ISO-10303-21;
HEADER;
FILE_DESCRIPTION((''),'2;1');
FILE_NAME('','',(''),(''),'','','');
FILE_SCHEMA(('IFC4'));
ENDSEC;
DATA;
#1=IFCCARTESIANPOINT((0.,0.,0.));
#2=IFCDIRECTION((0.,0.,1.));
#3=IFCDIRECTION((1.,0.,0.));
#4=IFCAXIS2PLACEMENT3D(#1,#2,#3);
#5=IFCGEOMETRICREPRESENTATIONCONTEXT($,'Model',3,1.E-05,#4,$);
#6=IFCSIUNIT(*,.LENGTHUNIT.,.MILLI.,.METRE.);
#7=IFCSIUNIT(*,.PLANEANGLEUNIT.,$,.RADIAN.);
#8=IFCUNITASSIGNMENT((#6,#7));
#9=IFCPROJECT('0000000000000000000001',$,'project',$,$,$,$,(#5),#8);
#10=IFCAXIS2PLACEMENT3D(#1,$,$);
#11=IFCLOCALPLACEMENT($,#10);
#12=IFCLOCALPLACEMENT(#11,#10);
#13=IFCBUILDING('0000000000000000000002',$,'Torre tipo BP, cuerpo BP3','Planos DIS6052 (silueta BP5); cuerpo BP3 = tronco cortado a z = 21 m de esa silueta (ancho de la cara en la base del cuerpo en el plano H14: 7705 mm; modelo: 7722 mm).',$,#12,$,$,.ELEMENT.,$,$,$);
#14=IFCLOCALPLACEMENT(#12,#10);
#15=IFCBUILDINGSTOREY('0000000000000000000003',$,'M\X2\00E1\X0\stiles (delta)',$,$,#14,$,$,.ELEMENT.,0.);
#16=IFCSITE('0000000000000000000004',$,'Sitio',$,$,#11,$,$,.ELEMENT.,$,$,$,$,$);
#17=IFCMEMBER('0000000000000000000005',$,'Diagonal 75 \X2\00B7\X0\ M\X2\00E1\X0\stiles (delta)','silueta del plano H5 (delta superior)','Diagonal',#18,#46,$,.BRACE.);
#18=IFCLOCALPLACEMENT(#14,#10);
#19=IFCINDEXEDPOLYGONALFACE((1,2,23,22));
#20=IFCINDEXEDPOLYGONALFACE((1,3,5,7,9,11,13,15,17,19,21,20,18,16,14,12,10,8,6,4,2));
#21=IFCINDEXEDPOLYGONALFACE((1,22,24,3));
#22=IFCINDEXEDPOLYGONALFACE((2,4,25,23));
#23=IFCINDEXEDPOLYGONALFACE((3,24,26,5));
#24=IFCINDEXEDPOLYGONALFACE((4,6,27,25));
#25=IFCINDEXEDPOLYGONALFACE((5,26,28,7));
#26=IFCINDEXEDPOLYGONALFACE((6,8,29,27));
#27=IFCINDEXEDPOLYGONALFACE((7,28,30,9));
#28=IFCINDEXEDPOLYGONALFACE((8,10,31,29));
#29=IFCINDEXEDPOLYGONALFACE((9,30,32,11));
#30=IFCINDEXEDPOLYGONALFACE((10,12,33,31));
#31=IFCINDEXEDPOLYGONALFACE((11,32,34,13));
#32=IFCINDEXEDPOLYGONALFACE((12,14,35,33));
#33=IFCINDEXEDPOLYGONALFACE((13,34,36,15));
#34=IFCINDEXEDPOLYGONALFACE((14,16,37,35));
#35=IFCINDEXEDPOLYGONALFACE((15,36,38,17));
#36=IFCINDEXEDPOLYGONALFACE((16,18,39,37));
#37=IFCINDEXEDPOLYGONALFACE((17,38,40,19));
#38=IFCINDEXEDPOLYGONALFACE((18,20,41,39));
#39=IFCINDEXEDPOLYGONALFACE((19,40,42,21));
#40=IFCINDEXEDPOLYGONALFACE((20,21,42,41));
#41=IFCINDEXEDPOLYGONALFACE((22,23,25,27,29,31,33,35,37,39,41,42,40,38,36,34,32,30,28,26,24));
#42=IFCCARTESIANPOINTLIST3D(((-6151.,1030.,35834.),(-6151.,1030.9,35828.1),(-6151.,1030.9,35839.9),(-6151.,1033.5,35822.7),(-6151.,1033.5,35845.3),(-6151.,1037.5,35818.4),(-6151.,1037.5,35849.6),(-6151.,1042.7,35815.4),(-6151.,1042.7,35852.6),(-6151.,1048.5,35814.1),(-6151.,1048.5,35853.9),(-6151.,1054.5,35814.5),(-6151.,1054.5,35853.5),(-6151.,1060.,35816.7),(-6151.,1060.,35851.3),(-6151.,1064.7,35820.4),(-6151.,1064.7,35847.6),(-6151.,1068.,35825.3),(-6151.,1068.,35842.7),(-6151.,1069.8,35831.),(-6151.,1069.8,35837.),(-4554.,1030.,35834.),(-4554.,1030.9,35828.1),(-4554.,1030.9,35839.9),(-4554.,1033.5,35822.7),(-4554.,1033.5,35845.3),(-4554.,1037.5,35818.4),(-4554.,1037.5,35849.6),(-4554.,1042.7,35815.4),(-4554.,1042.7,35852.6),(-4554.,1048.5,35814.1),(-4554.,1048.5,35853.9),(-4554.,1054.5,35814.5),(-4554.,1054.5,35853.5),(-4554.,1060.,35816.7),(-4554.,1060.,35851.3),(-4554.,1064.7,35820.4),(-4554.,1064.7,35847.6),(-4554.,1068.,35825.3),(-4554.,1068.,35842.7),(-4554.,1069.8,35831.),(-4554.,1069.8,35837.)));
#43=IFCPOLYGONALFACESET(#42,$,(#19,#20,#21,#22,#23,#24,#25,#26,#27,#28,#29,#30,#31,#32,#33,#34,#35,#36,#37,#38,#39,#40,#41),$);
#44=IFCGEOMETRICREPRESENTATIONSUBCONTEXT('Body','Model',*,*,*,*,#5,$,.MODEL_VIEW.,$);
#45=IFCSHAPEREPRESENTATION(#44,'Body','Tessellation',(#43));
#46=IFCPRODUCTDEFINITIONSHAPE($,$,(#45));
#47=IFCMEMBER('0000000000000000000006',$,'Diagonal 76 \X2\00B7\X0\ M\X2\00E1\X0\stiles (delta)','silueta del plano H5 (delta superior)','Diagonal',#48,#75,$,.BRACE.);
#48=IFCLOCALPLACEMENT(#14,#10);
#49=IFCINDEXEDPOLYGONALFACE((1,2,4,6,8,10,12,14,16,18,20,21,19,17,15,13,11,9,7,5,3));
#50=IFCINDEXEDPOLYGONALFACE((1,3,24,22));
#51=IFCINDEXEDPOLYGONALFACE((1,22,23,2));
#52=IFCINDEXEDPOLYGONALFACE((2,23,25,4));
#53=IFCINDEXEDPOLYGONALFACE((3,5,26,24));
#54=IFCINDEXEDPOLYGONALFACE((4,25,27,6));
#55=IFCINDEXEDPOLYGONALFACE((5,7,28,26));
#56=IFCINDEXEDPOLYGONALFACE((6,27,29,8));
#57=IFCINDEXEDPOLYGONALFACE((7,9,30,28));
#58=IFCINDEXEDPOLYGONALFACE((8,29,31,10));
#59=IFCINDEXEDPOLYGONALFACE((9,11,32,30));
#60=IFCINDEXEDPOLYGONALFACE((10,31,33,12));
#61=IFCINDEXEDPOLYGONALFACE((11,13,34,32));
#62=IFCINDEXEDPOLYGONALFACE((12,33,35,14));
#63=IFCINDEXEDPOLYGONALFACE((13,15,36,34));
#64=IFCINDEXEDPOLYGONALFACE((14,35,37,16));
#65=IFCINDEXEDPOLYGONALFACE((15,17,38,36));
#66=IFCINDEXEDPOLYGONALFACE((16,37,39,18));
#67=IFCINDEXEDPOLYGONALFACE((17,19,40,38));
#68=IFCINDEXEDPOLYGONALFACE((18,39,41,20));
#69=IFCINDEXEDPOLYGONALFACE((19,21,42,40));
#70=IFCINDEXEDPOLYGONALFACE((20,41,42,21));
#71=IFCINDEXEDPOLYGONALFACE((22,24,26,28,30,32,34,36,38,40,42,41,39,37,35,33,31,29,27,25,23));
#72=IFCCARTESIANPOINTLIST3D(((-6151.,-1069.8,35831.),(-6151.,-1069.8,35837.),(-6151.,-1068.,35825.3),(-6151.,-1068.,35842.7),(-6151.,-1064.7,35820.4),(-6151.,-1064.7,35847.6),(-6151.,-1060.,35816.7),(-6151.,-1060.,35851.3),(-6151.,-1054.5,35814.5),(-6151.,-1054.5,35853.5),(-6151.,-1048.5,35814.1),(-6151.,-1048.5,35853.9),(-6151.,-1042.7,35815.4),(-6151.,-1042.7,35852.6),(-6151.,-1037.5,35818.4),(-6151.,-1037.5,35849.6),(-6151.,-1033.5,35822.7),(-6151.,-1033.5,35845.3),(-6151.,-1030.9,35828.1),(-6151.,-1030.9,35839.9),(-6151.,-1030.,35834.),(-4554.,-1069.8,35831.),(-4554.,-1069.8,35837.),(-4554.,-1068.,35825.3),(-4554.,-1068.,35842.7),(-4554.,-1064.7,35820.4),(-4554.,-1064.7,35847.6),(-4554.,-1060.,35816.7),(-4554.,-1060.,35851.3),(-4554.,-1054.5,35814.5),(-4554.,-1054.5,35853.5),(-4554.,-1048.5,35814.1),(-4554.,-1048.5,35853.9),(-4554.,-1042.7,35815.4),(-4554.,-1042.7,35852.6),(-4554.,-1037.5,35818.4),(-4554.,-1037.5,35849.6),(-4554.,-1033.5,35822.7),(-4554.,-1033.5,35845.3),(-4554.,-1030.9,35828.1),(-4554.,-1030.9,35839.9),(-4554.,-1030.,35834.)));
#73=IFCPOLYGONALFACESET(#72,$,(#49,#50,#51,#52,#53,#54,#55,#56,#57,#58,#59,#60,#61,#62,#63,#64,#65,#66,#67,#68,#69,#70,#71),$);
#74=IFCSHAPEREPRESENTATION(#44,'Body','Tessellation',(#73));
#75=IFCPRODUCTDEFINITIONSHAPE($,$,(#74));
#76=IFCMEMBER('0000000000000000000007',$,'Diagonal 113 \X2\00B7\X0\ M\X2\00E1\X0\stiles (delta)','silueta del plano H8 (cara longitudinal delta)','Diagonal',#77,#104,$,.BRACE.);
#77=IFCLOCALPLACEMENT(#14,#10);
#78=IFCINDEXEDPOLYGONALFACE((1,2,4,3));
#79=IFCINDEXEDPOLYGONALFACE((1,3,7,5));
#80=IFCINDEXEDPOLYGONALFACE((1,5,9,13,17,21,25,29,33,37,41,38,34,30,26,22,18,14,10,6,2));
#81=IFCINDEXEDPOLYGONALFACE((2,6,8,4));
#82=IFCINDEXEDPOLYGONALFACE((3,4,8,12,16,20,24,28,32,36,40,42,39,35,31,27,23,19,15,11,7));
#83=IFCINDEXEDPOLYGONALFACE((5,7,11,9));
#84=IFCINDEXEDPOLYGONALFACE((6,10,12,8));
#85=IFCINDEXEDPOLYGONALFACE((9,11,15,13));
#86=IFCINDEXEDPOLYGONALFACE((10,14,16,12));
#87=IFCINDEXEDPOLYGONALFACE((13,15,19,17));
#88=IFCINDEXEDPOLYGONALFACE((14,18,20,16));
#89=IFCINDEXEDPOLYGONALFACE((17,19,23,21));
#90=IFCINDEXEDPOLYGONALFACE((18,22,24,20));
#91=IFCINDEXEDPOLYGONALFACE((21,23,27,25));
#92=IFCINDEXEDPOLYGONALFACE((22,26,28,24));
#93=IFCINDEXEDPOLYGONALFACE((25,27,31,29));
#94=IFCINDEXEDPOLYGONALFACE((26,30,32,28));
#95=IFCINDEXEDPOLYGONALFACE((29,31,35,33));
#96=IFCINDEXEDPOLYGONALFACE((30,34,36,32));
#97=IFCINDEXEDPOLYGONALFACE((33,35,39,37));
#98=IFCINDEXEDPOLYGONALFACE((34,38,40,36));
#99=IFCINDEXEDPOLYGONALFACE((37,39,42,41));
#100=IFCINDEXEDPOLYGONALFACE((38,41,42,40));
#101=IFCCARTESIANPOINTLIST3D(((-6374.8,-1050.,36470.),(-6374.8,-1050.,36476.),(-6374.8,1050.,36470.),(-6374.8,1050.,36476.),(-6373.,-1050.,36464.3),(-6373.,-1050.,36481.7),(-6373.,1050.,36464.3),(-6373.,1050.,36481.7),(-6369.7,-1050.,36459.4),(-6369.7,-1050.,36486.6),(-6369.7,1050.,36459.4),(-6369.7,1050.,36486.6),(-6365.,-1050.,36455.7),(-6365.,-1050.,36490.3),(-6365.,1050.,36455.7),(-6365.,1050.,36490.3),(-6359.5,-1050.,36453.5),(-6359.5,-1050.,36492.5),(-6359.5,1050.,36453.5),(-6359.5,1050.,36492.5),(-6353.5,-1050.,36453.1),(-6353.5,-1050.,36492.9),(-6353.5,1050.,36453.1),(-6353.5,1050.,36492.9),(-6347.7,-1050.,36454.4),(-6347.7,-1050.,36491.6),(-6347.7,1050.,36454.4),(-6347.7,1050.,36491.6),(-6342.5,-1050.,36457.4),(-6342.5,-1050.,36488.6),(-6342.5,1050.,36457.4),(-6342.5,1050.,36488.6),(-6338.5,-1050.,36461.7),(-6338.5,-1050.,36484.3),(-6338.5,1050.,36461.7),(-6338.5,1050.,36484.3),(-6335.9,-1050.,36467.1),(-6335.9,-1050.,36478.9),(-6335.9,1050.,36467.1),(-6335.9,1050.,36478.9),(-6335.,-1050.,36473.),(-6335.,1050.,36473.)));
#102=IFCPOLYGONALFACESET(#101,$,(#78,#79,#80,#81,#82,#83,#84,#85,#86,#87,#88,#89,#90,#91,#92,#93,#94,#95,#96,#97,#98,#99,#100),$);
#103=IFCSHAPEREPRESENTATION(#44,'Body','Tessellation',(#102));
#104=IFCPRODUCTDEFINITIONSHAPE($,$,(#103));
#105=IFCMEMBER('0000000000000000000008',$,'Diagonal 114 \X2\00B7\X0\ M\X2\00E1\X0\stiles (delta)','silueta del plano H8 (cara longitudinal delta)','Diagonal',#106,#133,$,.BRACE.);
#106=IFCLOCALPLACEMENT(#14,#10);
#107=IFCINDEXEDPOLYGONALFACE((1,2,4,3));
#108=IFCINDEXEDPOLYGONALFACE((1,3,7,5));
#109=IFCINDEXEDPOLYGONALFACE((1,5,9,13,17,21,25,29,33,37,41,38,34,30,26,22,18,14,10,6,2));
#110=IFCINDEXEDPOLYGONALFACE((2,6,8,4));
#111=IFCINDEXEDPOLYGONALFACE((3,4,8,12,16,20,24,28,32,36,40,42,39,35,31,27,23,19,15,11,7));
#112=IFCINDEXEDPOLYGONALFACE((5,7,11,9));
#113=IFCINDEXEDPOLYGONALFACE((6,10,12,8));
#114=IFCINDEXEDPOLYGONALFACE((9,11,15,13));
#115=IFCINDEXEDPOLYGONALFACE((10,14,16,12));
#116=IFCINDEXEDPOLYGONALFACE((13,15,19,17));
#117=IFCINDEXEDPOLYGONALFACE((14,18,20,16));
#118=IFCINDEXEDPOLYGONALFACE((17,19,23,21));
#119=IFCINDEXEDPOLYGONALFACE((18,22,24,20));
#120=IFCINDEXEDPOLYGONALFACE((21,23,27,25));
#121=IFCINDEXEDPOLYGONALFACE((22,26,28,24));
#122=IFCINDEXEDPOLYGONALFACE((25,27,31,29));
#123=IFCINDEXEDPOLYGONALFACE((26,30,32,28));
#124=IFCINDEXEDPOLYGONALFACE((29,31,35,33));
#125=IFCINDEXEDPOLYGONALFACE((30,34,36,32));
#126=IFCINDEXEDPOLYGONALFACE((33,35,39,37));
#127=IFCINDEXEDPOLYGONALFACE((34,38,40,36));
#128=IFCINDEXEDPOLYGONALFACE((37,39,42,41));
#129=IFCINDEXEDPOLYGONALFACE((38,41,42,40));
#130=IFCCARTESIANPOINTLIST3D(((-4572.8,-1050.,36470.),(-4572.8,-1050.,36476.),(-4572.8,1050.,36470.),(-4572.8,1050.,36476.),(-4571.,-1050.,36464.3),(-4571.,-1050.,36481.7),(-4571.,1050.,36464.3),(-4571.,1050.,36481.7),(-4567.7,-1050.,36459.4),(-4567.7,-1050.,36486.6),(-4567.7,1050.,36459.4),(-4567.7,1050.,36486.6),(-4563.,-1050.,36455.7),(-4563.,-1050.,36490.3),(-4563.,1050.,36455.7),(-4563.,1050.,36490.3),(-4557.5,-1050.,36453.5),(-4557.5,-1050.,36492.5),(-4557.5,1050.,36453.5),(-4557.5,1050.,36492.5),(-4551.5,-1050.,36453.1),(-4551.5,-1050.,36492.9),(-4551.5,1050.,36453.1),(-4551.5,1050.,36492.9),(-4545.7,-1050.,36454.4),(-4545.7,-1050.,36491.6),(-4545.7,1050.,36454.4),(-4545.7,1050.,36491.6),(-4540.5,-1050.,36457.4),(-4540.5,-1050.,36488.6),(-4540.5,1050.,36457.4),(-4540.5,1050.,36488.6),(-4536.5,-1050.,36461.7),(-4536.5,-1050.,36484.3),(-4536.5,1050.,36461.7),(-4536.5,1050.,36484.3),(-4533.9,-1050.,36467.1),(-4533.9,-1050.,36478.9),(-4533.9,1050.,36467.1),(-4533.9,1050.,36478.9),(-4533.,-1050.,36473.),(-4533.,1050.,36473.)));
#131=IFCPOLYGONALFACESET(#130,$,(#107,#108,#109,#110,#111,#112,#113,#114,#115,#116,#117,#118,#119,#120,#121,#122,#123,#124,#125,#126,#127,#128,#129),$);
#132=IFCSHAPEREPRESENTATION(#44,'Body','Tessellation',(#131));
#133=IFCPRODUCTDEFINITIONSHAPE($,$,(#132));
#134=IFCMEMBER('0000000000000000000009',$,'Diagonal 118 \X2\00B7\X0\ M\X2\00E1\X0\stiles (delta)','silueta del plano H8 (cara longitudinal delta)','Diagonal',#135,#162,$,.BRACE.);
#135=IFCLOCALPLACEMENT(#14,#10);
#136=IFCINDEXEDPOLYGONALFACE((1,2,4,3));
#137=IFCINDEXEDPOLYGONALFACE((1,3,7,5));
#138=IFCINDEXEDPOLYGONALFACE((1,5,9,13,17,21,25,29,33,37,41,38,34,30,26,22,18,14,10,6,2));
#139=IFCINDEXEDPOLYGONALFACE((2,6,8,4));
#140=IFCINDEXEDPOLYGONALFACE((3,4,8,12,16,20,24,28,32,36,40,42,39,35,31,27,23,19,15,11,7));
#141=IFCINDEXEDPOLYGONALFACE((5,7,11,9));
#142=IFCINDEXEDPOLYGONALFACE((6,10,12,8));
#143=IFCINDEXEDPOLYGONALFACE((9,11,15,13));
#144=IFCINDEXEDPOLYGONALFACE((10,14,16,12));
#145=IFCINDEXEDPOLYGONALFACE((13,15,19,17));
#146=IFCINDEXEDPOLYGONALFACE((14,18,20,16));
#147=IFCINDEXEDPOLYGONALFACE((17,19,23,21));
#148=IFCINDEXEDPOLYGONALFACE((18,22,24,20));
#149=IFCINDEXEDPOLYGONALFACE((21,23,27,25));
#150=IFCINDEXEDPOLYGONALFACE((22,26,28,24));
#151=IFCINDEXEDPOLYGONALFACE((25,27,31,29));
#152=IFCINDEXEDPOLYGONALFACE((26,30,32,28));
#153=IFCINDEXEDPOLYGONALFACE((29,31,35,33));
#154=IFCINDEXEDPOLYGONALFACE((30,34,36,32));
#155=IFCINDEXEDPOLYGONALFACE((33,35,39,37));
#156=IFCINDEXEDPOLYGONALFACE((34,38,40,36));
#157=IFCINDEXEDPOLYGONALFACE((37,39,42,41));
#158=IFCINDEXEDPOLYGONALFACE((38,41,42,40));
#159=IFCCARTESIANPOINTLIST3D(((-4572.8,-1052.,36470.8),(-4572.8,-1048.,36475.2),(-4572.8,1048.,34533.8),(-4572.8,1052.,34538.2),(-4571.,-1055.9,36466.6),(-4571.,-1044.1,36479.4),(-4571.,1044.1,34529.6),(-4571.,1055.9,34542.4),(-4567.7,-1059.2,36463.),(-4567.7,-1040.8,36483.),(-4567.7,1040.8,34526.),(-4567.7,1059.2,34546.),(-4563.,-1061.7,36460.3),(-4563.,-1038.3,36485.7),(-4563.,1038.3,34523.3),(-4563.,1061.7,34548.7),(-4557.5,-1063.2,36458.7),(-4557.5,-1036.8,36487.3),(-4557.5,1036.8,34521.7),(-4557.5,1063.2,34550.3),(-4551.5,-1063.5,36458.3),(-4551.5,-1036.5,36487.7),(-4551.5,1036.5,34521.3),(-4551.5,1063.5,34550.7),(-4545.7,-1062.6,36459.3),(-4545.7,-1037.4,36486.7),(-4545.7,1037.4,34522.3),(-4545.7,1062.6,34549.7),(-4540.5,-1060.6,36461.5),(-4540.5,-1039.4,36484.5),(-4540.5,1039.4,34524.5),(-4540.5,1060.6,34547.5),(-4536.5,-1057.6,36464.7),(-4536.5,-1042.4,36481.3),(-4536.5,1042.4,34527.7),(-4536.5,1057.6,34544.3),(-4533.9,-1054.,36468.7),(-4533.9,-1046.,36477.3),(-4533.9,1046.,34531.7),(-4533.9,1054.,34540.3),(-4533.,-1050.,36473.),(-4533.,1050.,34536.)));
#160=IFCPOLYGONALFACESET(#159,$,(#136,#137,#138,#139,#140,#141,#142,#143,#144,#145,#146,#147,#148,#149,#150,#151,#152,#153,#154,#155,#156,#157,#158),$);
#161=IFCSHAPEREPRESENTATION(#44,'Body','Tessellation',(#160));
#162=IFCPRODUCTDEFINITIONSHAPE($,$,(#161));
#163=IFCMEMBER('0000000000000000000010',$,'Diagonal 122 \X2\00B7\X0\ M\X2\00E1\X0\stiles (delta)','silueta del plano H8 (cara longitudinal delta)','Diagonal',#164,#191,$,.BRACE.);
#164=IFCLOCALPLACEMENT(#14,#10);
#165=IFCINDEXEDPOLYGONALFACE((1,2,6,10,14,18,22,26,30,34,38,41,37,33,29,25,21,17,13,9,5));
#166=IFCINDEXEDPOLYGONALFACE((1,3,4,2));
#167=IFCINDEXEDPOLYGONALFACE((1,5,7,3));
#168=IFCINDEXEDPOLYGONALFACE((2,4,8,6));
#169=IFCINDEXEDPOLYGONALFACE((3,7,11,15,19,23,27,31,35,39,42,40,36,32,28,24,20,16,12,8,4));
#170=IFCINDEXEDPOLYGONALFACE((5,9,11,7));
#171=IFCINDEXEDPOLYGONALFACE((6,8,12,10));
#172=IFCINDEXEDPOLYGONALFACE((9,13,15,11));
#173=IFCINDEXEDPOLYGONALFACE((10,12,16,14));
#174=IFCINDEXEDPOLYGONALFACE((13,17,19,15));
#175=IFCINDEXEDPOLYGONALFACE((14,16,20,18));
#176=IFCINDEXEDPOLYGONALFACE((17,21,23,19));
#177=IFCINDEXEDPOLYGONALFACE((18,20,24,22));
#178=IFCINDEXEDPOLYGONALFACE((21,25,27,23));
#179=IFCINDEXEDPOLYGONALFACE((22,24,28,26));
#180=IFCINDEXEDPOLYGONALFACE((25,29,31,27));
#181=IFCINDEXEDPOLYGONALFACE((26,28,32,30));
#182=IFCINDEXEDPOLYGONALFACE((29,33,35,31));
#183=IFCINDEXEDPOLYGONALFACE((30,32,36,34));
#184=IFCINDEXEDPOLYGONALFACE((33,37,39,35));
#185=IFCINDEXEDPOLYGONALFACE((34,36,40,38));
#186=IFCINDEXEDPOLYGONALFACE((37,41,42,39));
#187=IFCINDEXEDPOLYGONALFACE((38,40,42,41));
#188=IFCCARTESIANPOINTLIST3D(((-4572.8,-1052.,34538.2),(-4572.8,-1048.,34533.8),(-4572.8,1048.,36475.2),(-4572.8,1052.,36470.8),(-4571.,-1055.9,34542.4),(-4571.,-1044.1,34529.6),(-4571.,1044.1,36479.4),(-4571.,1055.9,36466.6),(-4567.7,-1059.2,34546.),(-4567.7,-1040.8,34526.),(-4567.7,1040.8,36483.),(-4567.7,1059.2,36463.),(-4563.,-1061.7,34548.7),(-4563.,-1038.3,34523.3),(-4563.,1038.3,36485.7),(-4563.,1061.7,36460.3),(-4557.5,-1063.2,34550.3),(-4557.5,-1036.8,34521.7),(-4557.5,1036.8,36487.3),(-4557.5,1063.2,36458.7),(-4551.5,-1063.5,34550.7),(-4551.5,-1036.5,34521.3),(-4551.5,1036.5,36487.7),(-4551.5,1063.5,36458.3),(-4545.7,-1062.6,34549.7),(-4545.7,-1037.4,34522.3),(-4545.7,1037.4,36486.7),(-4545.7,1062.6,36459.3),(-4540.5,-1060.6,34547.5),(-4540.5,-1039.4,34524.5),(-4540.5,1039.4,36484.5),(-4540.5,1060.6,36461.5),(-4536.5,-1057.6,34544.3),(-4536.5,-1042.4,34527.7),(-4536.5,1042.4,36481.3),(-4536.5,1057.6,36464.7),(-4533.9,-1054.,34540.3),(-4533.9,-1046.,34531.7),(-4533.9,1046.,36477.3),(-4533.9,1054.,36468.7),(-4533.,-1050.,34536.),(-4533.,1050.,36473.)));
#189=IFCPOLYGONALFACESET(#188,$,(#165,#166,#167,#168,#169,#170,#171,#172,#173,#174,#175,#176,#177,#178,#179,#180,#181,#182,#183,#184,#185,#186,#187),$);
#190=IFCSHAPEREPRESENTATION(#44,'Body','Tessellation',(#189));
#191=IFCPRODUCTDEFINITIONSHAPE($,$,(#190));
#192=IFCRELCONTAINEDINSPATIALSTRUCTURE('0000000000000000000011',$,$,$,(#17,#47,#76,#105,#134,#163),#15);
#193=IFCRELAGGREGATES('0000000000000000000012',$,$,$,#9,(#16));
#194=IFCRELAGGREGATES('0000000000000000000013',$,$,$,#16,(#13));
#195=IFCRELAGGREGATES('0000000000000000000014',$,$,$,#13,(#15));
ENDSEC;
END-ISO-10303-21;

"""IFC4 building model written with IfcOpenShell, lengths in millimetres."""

from ifc_helpers import new_model, si_unit, frame, origin, origin_with_axes, place, context, subcontext, project, spatial, circle, extrude, element, save


model = new_model("IFC4")

# Units and contexts
model_context = context("Model", 3, precision=1e-05, world=origin_with_axes())
body_context = subcontext(model_context, "Body", "Model", "MODEL_VIEW")
ifc_project = project(units=[si_unit("LENGTHUNIT", "METRE", prefix="MILLI"), si_unit("PLANEANGLEUNIT", "RADIAN")], contexts=[model_context])

# Site, building, storey
site_placement = place(None, origin())
site = spatial("IfcSite", under=ifc_project, at=site_placement, Name="Sitio", CompositionType="ELEMENT")
building_placement = place(site_placement, origin())
building = spatial("IfcBuilding", under=site, at=building_placement, Name="Torre tipo BP, cuerpo BP3", Description="Planos DIS6052 (silueta BP5); cuerpo BP3 = tronco cortado a z = 21 m de esa silueta (ancho de la cara en la base del cuerpo en el plano H14: 7705 mm; modelo: 7722 mm).", CompositionType="ELEMENT")
storey_placement = place(building_placement, origin())
storey = spatial("IfcBuildingStorey", under=building, at=storey_placement, Name="Mástiles (delta)", CompositionType="ELEMENT", Elevation=0.0)

# Members
for number, where, z_axis, x_axis, name in (
    (1, (-4554.0, 1050.0, 35834.0), (-1.0, 0.0, 0.0), (0.0, -1.0, 0.0), "Diagonal 75 · Mástiles (delta)"),
    (2, (-4554.0, -1050.0, 35834.0), (-1.0, 0.0, 0.0), (0.0, 1.0, 0.0), "Diagonal 76 · Mástiles (delta)"),
):
    element("IfcMember", number, at=place(storey_placement, frame(where, z_axis=z_axis, x_axis=x_axis)), inside=storey, Name=name, Description="silueta del plano H5 (delta superior)", ObjectType="Diagonal", PredefinedType="BRACE", context=body_context, shape_type="SweptSolid", body=[
        extrude(circle(Radius=20.0), None, (0.0, 0.0, 1.0), 1597.0),
    ])
for number, where, z_axis, x_axis, name in (
    (3, (-6355.0, -1050.0, 36473.0), (0.0, 1.0, 0.0), (1.0, 0.0, 0.0), "Diagonal 113 · Mástiles (delta)"),
    (4, (-4553.0, -1050.0, 36473.0), (0.0, 1.0, 0.0), (1.0, 0.0, 0.0), "Diagonal 114 · Mástiles (delta)"),
):
    element("IfcMember", number, at=place(storey_placement, frame(where, z_axis=z_axis, x_axis=x_axis)), inside=storey, Name=name, Description="silueta del plano H8 (cara longitudinal delta)", ObjectType="Diagonal", PredefinedType="BRACE", context=body_context, shape_type="SweptSolid", body=[
        extrude(circle(Radius=20.0), None, (0.0, 0.0, 1.0), 2100.0),
    ])
member_1_placement = place(storey_placement, frame((-4553.0, -1050.0, 36473.0), z_axis=(0.0, 0.735058, -0.678004), x_axis=(1.0, 0.0, 0.0)))
element("IfcMember", 5, at=member_1_placement, inside=storey, Name="Diagonal 118 · Mástiles (delta)", Description="silueta del plano H8 (cara longitudinal delta)", ObjectType="Diagonal", PredefinedType="BRACE", context=body_context, shape_type="SweptSolid", body=[
    extrude(circle(Radius=20.0), None, (0.0, 0.0, 1.0), 2856.9),
])
member_2_placement = place(storey_placement, frame((-4553.0, 1050.0, 36473.0), z_axis=(0.0, -0.735058, -0.678004), x_axis=(1.0, 0.0, 0.0)))
element("IfcMember", 6, at=member_2_placement, inside=storey, Name="Diagonal 122 · Mástiles (delta)", Description="silueta del plano H8 (cara longitudinal delta)", ObjectType="Diagonal", PredefinedType="BRACE", context=body_context, shape_type="SweptSolid", body=[
    extrude(circle(Radius=20.0), None, (0.0, 0.0, 1.0), 2856.9),
])

save(model, "model.ifc")
